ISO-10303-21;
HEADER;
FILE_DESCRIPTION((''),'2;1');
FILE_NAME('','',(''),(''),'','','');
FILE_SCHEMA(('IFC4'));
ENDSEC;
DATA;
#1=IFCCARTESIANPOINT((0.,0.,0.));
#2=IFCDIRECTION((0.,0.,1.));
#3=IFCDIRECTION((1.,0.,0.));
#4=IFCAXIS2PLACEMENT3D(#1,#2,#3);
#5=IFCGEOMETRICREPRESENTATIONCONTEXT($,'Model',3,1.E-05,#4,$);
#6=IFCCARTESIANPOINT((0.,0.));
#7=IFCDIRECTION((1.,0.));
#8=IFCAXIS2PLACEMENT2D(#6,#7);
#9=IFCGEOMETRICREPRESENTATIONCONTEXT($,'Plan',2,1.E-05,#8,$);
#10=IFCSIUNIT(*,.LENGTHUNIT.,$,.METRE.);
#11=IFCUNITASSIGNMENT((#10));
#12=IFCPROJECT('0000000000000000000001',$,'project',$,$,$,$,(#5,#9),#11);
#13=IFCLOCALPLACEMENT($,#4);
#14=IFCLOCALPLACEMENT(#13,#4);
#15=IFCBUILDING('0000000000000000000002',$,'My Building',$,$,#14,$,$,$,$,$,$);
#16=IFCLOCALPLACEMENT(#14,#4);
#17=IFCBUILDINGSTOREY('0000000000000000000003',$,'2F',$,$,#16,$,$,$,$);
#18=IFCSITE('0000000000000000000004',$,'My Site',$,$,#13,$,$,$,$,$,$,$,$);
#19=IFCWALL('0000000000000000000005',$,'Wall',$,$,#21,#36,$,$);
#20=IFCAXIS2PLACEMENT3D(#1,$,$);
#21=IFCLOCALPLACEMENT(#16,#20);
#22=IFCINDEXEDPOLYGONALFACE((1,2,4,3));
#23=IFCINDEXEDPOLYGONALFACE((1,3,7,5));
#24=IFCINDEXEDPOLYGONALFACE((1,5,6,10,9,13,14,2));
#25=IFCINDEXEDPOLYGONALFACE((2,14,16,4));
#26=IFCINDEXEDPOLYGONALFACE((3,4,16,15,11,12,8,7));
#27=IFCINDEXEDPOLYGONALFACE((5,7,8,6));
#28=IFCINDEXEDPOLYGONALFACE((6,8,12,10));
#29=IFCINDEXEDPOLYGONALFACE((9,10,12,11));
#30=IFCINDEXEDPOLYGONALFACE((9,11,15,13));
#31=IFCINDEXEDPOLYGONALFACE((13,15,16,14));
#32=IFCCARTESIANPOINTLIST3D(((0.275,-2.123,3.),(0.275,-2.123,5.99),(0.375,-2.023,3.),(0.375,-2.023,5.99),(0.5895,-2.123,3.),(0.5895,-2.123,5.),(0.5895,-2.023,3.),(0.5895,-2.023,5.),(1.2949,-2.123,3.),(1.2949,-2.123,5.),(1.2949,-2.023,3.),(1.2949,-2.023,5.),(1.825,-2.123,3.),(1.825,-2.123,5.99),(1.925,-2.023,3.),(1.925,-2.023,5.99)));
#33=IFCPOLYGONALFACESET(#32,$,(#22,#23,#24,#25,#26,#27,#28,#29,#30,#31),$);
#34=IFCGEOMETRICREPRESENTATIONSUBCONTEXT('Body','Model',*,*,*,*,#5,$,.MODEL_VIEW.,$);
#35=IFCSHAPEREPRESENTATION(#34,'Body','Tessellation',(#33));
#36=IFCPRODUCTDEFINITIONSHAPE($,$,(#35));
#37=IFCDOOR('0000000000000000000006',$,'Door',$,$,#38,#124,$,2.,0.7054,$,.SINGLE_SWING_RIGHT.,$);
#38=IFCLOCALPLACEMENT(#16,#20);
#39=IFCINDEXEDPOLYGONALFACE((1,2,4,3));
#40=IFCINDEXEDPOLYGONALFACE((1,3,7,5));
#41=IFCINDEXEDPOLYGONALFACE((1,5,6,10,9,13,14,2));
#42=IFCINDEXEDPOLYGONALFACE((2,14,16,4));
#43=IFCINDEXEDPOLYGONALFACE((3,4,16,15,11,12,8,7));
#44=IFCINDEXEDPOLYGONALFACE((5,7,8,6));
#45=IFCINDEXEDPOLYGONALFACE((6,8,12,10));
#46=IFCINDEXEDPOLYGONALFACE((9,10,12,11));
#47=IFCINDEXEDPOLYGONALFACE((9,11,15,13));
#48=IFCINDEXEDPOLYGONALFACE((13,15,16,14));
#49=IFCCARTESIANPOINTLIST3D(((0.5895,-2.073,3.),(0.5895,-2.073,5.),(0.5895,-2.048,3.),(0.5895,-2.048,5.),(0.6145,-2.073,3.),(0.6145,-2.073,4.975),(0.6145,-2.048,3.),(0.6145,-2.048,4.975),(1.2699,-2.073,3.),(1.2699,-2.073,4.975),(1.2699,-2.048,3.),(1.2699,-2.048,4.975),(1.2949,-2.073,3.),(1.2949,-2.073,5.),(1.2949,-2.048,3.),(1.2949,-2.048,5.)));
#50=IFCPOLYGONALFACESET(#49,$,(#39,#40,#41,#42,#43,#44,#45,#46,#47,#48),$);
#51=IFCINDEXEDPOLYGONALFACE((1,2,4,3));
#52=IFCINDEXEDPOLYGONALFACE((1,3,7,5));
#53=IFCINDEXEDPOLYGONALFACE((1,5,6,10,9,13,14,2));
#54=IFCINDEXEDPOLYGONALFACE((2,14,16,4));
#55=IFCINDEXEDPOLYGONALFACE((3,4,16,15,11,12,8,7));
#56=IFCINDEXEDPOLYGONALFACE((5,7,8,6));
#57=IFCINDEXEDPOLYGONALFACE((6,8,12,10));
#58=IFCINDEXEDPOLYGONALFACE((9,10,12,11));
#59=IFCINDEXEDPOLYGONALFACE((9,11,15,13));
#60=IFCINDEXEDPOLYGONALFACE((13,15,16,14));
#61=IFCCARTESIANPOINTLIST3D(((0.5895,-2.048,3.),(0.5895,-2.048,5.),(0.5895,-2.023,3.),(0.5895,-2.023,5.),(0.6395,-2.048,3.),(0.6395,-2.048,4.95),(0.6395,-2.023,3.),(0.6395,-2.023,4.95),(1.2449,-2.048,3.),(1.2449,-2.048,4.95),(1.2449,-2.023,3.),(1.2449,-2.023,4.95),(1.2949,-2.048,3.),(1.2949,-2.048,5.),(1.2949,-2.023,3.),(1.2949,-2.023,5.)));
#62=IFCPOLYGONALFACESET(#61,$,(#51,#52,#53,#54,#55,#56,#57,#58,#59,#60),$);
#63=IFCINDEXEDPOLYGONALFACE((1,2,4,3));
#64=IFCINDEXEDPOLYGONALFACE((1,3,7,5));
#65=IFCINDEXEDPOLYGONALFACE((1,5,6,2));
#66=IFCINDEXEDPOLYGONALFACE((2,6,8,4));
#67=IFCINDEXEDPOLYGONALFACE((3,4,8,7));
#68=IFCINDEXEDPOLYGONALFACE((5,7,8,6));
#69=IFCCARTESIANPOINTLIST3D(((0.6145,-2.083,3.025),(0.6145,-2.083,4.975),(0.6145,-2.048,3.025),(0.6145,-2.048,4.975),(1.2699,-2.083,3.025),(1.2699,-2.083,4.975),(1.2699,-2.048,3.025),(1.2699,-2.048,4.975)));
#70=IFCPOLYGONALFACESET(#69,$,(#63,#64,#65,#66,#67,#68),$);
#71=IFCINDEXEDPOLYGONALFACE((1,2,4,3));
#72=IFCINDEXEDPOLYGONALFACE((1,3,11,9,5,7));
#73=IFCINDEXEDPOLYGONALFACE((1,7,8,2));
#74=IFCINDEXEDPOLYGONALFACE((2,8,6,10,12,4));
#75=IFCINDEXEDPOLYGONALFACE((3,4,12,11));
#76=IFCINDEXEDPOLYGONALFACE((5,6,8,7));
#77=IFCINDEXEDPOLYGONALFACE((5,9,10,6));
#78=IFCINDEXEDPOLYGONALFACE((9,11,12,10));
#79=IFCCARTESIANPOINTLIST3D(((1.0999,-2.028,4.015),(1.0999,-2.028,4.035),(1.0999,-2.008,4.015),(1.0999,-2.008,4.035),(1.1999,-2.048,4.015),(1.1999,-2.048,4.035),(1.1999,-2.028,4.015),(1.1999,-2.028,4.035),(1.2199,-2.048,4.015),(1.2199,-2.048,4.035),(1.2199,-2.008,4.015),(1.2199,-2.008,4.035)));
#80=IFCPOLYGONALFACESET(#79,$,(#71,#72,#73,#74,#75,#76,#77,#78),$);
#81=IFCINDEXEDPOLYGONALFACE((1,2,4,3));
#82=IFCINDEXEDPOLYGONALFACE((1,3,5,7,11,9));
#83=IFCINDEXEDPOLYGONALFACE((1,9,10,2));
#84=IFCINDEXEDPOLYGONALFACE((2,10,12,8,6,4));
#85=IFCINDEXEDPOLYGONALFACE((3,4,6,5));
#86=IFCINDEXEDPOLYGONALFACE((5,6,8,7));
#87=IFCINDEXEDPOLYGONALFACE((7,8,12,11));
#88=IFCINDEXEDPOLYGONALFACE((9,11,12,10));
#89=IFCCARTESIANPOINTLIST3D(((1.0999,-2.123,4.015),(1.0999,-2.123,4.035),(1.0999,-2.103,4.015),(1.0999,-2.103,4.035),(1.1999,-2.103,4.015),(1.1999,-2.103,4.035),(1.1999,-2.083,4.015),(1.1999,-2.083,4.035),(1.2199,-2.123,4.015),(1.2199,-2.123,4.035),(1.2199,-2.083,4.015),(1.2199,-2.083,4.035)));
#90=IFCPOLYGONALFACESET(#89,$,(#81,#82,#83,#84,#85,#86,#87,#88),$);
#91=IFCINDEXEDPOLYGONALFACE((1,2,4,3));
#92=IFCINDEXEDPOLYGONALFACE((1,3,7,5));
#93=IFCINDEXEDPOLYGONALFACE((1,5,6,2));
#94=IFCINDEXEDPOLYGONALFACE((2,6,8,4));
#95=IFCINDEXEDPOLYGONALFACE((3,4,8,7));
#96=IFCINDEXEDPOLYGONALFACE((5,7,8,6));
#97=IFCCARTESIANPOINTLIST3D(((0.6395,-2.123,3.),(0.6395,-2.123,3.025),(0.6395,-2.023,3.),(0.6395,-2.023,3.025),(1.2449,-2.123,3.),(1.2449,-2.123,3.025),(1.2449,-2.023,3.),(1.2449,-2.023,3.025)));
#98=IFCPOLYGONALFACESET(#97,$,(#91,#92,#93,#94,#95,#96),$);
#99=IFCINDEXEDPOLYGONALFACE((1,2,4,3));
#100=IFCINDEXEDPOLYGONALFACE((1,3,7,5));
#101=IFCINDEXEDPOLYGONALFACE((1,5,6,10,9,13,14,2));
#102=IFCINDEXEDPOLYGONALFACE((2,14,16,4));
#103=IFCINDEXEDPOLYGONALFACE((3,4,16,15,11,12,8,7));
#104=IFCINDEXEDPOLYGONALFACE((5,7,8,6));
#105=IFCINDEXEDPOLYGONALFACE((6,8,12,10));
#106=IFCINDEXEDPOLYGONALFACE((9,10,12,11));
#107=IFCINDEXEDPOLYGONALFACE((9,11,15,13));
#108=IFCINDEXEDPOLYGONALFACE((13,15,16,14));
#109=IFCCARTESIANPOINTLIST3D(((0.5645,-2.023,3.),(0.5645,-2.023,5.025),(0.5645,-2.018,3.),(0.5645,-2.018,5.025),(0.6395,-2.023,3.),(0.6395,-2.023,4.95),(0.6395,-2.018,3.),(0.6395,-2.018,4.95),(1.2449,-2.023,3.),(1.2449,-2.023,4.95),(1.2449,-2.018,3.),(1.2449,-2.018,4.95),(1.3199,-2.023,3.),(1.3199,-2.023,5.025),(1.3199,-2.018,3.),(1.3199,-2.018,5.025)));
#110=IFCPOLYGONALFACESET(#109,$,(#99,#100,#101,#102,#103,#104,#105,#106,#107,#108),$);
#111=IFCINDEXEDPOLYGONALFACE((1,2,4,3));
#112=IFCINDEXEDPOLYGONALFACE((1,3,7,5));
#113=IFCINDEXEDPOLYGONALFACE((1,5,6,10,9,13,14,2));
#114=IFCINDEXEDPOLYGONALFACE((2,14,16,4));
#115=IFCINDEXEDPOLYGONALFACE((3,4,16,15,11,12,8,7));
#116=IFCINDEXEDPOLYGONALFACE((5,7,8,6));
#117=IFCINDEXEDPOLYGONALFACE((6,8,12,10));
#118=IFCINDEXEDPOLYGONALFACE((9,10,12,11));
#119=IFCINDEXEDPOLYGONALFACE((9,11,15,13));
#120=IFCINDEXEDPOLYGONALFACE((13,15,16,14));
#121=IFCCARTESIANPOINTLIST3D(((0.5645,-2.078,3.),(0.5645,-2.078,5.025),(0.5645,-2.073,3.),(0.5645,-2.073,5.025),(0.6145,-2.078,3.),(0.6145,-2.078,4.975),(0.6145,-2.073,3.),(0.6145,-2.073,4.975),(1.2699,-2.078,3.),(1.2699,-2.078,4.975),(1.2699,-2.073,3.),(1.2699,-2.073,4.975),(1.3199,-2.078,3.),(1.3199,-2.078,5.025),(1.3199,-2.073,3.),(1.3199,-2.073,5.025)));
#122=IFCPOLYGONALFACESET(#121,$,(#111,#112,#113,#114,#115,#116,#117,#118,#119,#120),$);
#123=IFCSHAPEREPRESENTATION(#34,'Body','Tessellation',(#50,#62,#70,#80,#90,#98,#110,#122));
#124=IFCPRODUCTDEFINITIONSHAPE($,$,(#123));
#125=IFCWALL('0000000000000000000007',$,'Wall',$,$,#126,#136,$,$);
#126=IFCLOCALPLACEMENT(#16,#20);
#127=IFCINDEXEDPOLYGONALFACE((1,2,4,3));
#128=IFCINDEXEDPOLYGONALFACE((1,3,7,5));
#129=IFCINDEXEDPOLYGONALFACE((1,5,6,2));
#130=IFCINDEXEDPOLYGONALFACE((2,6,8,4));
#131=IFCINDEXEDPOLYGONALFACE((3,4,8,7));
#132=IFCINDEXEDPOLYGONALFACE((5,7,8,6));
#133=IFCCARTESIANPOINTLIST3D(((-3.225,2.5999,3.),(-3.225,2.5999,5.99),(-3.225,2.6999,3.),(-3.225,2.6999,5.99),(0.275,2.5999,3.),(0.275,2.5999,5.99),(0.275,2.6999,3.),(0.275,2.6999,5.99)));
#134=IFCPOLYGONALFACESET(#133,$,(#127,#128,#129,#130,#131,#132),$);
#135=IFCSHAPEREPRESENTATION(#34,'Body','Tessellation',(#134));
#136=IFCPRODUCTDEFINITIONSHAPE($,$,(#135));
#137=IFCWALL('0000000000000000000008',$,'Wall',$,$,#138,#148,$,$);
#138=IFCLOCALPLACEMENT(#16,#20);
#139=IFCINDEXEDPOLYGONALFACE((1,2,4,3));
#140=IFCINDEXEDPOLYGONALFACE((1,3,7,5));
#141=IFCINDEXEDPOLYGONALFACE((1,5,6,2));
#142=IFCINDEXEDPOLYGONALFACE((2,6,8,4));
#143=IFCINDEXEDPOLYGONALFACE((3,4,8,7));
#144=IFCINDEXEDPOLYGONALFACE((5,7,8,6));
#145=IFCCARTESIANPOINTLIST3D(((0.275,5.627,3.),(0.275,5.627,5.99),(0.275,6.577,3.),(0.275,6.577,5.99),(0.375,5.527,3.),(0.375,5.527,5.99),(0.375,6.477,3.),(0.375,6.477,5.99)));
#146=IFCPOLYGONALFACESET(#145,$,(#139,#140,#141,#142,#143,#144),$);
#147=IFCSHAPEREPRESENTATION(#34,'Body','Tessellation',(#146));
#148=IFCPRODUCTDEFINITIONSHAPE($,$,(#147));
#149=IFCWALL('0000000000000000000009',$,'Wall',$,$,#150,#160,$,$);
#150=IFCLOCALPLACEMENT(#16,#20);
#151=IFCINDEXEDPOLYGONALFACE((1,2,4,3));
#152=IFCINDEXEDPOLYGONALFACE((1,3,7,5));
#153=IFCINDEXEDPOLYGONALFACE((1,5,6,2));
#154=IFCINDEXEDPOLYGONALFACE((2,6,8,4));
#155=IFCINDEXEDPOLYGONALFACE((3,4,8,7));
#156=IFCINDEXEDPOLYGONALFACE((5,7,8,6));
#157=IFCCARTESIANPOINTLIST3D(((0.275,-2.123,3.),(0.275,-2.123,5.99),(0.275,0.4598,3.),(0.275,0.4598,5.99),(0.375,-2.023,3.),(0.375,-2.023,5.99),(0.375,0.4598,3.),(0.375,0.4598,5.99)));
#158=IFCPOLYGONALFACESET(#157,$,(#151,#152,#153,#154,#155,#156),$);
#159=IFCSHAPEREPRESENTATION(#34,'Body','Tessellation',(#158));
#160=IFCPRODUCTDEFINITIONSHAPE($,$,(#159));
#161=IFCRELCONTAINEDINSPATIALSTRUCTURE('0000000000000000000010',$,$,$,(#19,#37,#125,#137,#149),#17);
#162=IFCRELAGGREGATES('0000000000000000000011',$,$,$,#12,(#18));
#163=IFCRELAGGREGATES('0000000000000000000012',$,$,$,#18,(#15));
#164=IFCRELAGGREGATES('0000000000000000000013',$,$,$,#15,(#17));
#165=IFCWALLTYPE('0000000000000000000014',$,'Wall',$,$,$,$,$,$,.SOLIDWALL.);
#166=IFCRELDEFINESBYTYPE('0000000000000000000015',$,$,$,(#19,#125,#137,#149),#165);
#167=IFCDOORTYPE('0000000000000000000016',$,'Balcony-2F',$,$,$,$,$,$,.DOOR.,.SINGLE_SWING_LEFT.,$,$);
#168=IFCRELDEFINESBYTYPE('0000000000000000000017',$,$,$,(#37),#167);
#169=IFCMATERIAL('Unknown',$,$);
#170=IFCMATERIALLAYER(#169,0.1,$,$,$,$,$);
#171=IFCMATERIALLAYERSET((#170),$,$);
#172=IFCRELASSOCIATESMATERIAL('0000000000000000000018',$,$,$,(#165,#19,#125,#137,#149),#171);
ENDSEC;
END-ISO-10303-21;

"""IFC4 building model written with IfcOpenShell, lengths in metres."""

from ifc_helpers import new_model, entity, si_unit, frame, origin_with_axes, origin_2d_with_axis, place, context, subcontext, project, spatial, line, indexed_curve, outline, extrude, shape, source, transform, mapped, material, layer, layer_set, layer_usage, type_object, type_shapes, element, fill, save


model = new_model("IFC4")

# Units and contexts
model_context = context("Model", 3, precision=1e-05, world=origin_with_axes())
plan_context = context("Plan", 2, precision=1e-05, world=origin_2d_with_axis())
body_context_1 = subcontext(model_context, "Body", "Model", "MODEL_VIEW")
body_context_2 = subcontext(plan_context, "Body", "Plan", "PLAN_VIEW")
ifc_project = project(units=[si_unit("LENGTHUNIT", "METRE")], contexts=[model_context, plan_context])

# Site, building, storey
site_placement = place(None, origin_with_axes())
site = spatial("IfcSite", under=ifc_project, at=site_placement, Name="My Site")
building_placement = place(site_placement, origin_with_axes())
building = spatial("IfcBuilding", under=site, at=building_placement, Name="My Building")
storey_placement = place(building_placement, origin_with_axes())
storey = spatial("IfcBuildingStorey", under=building, at=storey_placement, Name="2F")

# Shared definitions
ifc_material = material(Name="Unknown")

# Shared definitions
ifc_layer_1 = layer(ifc_material, 0.1)
ifc_layer_set_1 = layer_set([ifc_layer_1])
wall_type = type_object("IfcWallType", Name="Wall", PredefinedType="SOLIDWALL", material=ifc_layer_set_1)

# Wall, opening, door
ifc_layer_usage_1 = layer_usage(ifc_layer_set_1, "AXIS2", "POSITIVE", 0.0)
wall_1_placement = place(storey_placement, frame((0.275, -2.123, 3.0), z_axis=(0.0, 0.0, 1.0), x_axis=(1.0, 0.000001, 0.0)))
wall_1 = element("IfcWall", 1, at=wall_1_placement, inside=storey, type_object=wall_type, material=ifc_layer_usage_1, Name="Wall", context=body_context_1, shape_type="SweptSolid", body=[
    extrude(outline(indexed_curve([(0.0, 0.0), (0.1, 0.1), (1.65, 0.1), (1.55, 0.0)], segments=[line(1, 2, 3, 4, 1)])), origin_with_axes(), (0.0, 0.0, 1.0), 2.99),
])
shared_shape_1 = source(origin_with_axes(), body_context_1, "Body", "SweptSolid", [
    extrude(outline(indexed_curve([(0.0, 0.0), (0.7054, 0.0), (0.7054, 2.0), (0.0, 2.0)], segments=[line(1, 2, 3, 4, 1)])), frame((0.0, -0.6, 0.0), z_axis=(0.0, -1.0, 0.0), x_axis=(1.0, 0.0, 0.0)), (0.0, 0.0, -1.0), 1.2),
])
opening_1_placement = place(wall_1_placement, frame((1.0199, 0.1, 0.0), z_axis=(0.0, 0.0, 1.0), x_axis=(-1.0, 0.0, 0.0)))
opening_1 = element("IfcOpeningElement", 2, at=opening_1_placement, cuts=wall_1, PredefinedType="OPENING", context=body_context_1, shape_type="MappedRepresentation", body=[
    mapped(shared_shape_1, transform((0.0, 0.0, 0.0), x_axis=(1.0, 0.0, 0.0), y_axis=(0.0, 1.0, 0.0), z_axis=(0.0, 0.0, 1.0), scale=1.0)),
])
door_type_1 = type_object("IfcDoorType", Name="Balcony-2F", OperationType="SINGLE_SWING_LEFT", PredefinedType="DOOR")
shared_shape_2 = source(origin_with_axes(), body_context_1, "Body", "SweptSolid", [
    extrude(outline(indexed_curve([(0.0, 0.0), (0.0, 2.0), (0.7054, 2.0), (0.7054, 0.0), (0.6804, 0.0), (0.6804, 1.975), (0.025, 1.975), (0.025, 0.0)], segments=[line(1, 2, 3, 4, 5, 6, 7, 8, 1)])), frame((0.0, 0.025, 0.0), z_axis=(0.0, -1.0, 0.0), x_axis=(1.0, 0.0, 0.0)), (0.0, 0.0, -1.0), 0.025),
    extrude(outline(indexed_curve([(0.0, 0.0), (0.0, 2.0), (0.7054, 2.0), (0.7054, 0.0), (0.6554, 0.0), (0.6554, 1.95), (0.05, 1.95), (0.05, 0.0)], segments=[line(1, 2, 3, 4, 5, 6, 7, 8, 1)])), frame((0.0, 0.0, 0.0), z_axis=(0.0, -1.0, 0.0), x_axis=(1.0, 0.0, 0.0)), (0.0, 0.0, -1.0), 0.025),
    extrude(outline(indexed_curve([(0.0, 0.0), (0.6554, 0.0), (0.6554, 0.035), (0.0, 0.035)], segments=[line(1, 2, 3, 4, 1)])), frame((0.025, 0.025, 0.025), z_axis=(0.0, 0.0, 1.0), x_axis=(1.0, 0.0, 0.0)), (0.0, 0.0, 1.0), 1.95),
    extrude(outline(indexed_curve([(0.0, 0.0), (0.0, -0.04), (0.12, -0.04), (0.12, -0.02), (0.02, -0.02), (0.02, 0.0)], segments=[line(1, 2, 3, 4, 5, 6, 1)])), frame((0.075, 0.025, 1.015), z_axis=(0.0, 0.0, 1.0), x_axis=(1.0, 0.0, 0.0)), (0.0, 0.0, 1.0), 0.02),
    extrude(outline(indexed_curve([(0.0, 0.0), (0.0, 0.04), (0.12, 0.04), (0.12, 0.02), (0.02, 0.02), (0.02, 0.0)], segments=[line(1, 2, 3, 4, 5, 6, 1)])), frame((0.075, 0.06, 1.015), z_axis=(0.0, 0.0, 1.0), x_axis=(1.0, 0.0, 0.0)), (0.0, 0.0, 1.0), 0.02),
    extrude(outline(indexed_curve([(0.0, 0.0), (0.6054, 0.0), (0.6054, 0.1), (0.0, 0.1)], segments=[line(1, 2, 3, 4, 1)])), frame((0.05, 0.0, 0.0), z_axis=(0.0, 0.0, 1.0), x_axis=(1.0, 0.0, 0.0)), (0.0, 0.0, 1.0), 0.025),
    extrude(outline(indexed_curve([(0.0, 0.0), (0.0, 2.025), (0.7554, 2.025), (0.7554, 0.0), (0.6804, 0.0), (0.6804, 1.95), (0.075, 1.95), (0.075, 0.0)], segments=[line(1, 2, 3, 4, 5, 6, 7, 8, 1)])), frame((-0.025, -0.005, 0.0), z_axis=(0.0, -1.0, 0.0), x_axis=(1.0, 0.0, 0.0)), (0.0, 0.0, -1.0), 0.005),
    extrude(outline(indexed_curve([(0.0, 0.0), (0.0, 2.025), (0.7554, 2.025), (0.7554, 0.0), (0.7054, 0.0), (0.7054, 1.975), (0.05, 1.975), (0.05, 0.0)], segments=[line(1, 2, 3, 4, 5, 6, 7, 8, 1)])), frame((-0.025, 0.05, 0.0), z_axis=(0.0, -1.0, 0.0), x_axis=(1.0, 0.0, 0.0)), (0.0, 0.0, -1.0), 0.005),
])
shared_shape_3 = source(origin_with_axes(), body_context_2, "Body", "Curve2D", [
    entity("IfcIndexedPolyCurve", entity("IfcCartesianPointList2D", [[0.0, 0.0], [0.0, 0.05], [0.025, 0.05], [0.025, 0.025], [0.05, 0.025], [0.05, 0.0]]), [entity("IfcLineIndex", [1, 2, 3, 4, 5, 6, 1])]),
    entity("IfcIndexedPolyCurve", entity("IfcCartesianPointList2D", [[0.7054, 0.0], [0.7054, 0.05], [0.6804, 0.05], [0.6804, 0.025], [0.6554, 0.025], [0.6554, 0.0]]), [entity("IfcLineIndex", [1, 2, 3, 4, 5, 6, 1])]),
    entity("IfcTrimmedCurve", entity("IfcEllipse", entity("IfcAxis2Placement2D", entity("IfcCartesianPoint", [0.6454, 0.05]), entity("IfcDirection", [1.0, 0.0])), 0.6204, 0.6554), [entity("IfcCartesianPoint", [0.6454, 0.7054])], [entity("IfcCartesianPoint", [0.025, 0.05])], True, "CARTESIAN"),
    entity("IfcIndexedPolyCurve", entity("IfcCartesianPointList2D", [[0.6804, 0.05], [0.6454, 0.05], [0.6454, 0.7054], [0.6804, 0.7054]]), [entity("IfcLineIndex", [1, 2, 3, 4, 1])]),
])
type_shapes(door_type_1, [shared_shape_2, shared_shape_3])
door_1_placement = place(opening_1_placement, frame((0.0, 0.0, 0.0), z_axis=(0.0, 0.0, 1.0), x_axis=(1.0, 0.0, 0.0)))
door_1 = element("IfcDoor", 3, at=door_1_placement, inside=storey, type_object=door_type_1, Name="Door", OperationType="SINGLE_SWING_RIGHT", OverallHeight=2.0, OverallWidth=0.7054, shapes=[
    shape(body_context_1, "Body", "MappedRepresentation", [mapped(shared_shape_2, transform((0.0, 0.0, 0.0), x_axis=(1.0, 0.0, 0.0), y_axis=(0.0, 1.0, 0.0), z_axis=(0.0, 0.0, 1.0), scale=1.0))]),
    shape(body_context_2, "Body", "MappedRepresentation", [mapped(shared_shape_3, transform((0.0, 0.0, 0.0), x_axis=(1.0, 0.0, 0.0), y_axis=(0.0, 1.0, 0.0), z_axis=(0.0, 0.0, 1.0), scale=1.0))]),
])
fill(opening_1, door_1)

# Wall
ifc_layer_usage_2 = layer_usage(ifc_layer_set_1, "AXIS2", "POSITIVE", 0.0)
wall_2_placement = place(storey_placement, frame((-3.225, 2.5999, 3.0), z_axis=(0.0, 0.0, 1.0), x_axis=(1.0, 0.0, 0.0)))
element("IfcWall", 4, at=wall_2_placement, inside=storey, type_object=wall_type, material=ifc_layer_usage_2, Name="Wall", context=body_context_1, shape_type="SweptSolid", body=[
    extrude(outline(indexed_curve([(0.0, 0.0), (0.0, 0.1), (3.5, 0.1), (3.5, 0.0)], segments=[line(1, 2, 3, 4, 1)])), origin_with_axes(), (0.0, 0.0, 1.0), 2.99),
])

# Walls
ifc_layer_usage_3 = layer_usage(ifc_layer_set_1, "AXIS2", "POSITIVE", 0.0)
wall_3_placement = place(storey_placement, frame((0.375, 5.627, 3.0), z_axis=(0.0, 0.0, 1.0), x_axis=(0.0, 1.0, 0.0)))
element("IfcWall", 5, at=wall_3_placement, inside=storey, type_object=wall_type, material=ifc_layer_usage_3, Name="Wall", context=body_context_1, shape_type="SweptSolid", body=[
    extrude(outline(indexed_curve([(-0.1, 0.0), (0.0, 0.1), (0.95, 0.1), (0.85, 0.0)], segments=[line(1, 2, 3, 4, 1)])), origin_with_axes(), (0.0, 0.0, 1.0), 2.99),
])
ifc_layer_usage_4 = layer_usage(ifc_layer_set_1, "AXIS2", "POSITIVE", 0.0)
wall_4_placement = place(storey_placement, frame((0.275, 0.4598, 3.0), z_axis=(0.0, 0.0, 1.0), x_axis=(0.0, -1.0, 0.0)))
element("IfcWall", 6, at=wall_4_placement, inside=storey, type_object=wall_type, material=ifc_layer_usage_4, Name="Wall", context=body_context_1, shape_type="SweptSolid", body=[
    extrude(outline(indexed_curve([(0.0, 0.0), (0.0, 0.1), (2.4828, 0.1), (2.5828, 0.0)], segments=[line(1, 2, 3, 4, 1)])), origin_with_axes(), (0.0, 0.0, 1.0), 2.99),
])

save(model, "model.ifc")
